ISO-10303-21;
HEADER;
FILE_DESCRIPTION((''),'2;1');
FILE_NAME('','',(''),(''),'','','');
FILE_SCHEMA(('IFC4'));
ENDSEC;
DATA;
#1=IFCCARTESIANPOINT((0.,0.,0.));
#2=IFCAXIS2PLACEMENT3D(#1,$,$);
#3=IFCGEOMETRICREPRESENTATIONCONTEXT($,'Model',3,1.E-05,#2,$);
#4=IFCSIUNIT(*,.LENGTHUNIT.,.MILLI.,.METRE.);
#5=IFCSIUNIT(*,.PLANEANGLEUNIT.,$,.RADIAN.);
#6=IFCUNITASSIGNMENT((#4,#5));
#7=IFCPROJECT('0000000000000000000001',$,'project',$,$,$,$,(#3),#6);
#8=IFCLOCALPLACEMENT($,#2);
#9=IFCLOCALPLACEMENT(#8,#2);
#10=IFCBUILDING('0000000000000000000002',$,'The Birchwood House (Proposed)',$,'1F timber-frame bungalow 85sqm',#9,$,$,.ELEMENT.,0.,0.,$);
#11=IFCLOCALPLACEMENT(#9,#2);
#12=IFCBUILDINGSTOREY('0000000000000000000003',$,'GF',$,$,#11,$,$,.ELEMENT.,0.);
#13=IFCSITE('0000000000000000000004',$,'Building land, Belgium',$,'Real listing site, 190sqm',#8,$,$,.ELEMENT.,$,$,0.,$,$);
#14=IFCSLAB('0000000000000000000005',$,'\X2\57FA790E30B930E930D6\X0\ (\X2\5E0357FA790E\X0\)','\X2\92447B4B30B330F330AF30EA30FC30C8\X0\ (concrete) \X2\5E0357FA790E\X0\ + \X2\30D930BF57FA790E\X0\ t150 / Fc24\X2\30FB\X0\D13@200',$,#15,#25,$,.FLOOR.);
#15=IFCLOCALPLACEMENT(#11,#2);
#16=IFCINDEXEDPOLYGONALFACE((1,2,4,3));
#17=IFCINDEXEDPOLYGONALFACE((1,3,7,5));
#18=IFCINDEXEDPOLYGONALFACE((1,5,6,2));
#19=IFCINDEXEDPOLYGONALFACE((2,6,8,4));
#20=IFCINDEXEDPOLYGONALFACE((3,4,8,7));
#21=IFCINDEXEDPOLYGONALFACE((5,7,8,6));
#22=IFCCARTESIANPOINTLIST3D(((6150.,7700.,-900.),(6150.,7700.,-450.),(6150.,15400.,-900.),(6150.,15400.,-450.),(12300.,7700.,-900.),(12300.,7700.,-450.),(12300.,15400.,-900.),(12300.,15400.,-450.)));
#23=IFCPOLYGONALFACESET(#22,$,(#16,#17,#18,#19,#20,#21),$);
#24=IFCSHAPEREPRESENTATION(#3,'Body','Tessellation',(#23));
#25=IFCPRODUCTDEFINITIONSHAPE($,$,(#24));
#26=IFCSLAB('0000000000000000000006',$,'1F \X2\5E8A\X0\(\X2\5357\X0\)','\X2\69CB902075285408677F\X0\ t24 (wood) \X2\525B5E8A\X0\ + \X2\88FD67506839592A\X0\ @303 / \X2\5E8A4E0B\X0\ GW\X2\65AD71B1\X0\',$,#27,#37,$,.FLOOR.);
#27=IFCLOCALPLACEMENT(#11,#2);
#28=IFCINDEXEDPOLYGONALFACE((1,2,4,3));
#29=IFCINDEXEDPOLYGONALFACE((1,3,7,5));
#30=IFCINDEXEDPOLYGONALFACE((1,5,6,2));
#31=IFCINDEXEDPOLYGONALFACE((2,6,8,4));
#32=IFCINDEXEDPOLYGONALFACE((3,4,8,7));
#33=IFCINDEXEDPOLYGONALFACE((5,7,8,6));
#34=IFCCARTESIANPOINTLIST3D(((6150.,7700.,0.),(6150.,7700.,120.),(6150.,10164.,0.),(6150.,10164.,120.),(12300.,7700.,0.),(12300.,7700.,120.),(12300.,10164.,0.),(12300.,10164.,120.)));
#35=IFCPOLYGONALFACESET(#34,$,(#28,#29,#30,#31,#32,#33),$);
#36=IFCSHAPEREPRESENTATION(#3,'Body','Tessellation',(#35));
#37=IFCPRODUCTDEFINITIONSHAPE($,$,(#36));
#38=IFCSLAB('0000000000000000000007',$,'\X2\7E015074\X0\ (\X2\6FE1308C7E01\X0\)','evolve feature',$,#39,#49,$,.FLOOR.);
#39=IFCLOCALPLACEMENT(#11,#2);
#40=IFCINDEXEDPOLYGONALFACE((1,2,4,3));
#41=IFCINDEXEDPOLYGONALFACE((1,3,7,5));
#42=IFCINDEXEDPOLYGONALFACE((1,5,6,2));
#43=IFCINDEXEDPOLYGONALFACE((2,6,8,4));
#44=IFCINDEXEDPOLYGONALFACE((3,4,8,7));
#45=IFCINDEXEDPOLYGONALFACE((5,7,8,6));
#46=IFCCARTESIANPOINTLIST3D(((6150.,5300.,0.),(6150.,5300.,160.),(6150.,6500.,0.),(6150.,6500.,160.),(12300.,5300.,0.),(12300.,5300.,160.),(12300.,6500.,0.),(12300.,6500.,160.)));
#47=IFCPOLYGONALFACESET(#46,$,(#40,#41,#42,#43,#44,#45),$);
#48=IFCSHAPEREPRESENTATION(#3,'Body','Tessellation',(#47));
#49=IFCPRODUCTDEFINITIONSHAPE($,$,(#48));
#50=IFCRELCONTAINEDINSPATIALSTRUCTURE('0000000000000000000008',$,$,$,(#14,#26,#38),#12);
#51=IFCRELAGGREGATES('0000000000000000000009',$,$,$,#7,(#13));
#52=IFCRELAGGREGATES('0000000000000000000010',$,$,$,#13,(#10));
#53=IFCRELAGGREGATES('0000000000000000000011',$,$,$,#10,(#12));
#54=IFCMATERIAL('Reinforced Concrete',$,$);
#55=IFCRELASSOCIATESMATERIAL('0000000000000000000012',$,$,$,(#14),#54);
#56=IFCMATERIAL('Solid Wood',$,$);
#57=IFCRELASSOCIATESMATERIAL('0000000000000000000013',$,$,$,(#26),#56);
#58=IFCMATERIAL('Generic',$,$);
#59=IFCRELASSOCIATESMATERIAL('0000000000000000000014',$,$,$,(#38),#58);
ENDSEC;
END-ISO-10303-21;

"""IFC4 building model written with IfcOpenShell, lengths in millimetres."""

from ifc_helpers import new_model, si_unit, frame, frame_2d, origin, place, context, project, spatial, rectangle, extrude, material, element, save


model = new_model("IFC4")

# Units and contexts
model_context = context("Model", 3, precision=1e-05, world=origin())
ifc_project = project(units=[si_unit("LENGTHUNIT", "METRE", prefix="MILLI"), si_unit("PLANEANGLEUNIT", "RADIAN")], contexts=[model_context])

# Site, building, storey
site_placement = place(None, origin())
site = spatial("IfcSite", under=ifc_project, at=site_placement, Name="Building land, Belgium", ObjectType="Real listing site, 190sqm", CompositionType="ELEMENT", RefElevation=0.0)
building_placement = place(site_placement, origin())
building = spatial("IfcBuilding", under=site, at=building_placement, Name="The Birchwood House (Proposed)", ObjectType="1F timber-frame bungalow 85sqm", CompositionType="ELEMENT", ElevationOfRefHeight=0.0, ElevationOfTerrain=0.0)
storey_placement = place(building_placement, origin())
storey = spatial("IfcBuildingStorey", under=building, at=storey_placement, Name="GF", CompositionType="ELEMENT", Elevation=0.0)

# Slabs
ifc_material_1 = material(Name="Reinforced Concrete")
slab_1_placement = place(storey_placement, frame((3075.0, 3850.0, -450.0)))
element("IfcSlab", 1, at=slab_1_placement, inside=storey, material=ifc_material_1, Name="基礎スラブ (布基礎)", Description="鉄筋コンクリート (concrete) 布基礎 + ベタ基礎 t150 / Fc24・D13@200", PredefinedType="FLOOR", context=model_context, shape_type="SweptSolid", body=[
    extrude(rectangle(XDim=6150.0, YDim=7700.0, at=frame_2d((3075.0, 3850.0))), frame((3075.0, 3850.0, -450.0)), (0.0, 0.0, 1.0), 450.0),
])
ifc_material_2 = material(Name="Solid Wood")
slab_2_placement = place(storey_placement, frame((3075.0, 3850.0, 0.0)))
element("IfcSlab", 2, at=slab_2_placement, inside=storey, material=ifc_material_2, Name="1F 床(南)", Description="構造用合板 t24 (wood) 剛床 + 製材根太 @303 / 床下 GW断熱", PredefinedType="FLOOR", context=model_context, shape_type="SweptSolid", body=[
    extrude(rectangle(XDim=6150.0, YDim=2464.0, at=frame_2d((3075.0, 1232.0))), frame((3075.0, 3850.0, 0.0)), (0.0, 0.0, 1.0), 120.0),
])
ifc_material_3 = material(Name="Generic")
slab_3_placement = place(storey_placement, frame((3075.0, 2650.0, 0.0)))
element("IfcSlab", 3, at=slab_3_placement, inside=storey, material=ifc_material_3, Name="縁側 (濡れ縁)", Description="evolve feature", PredefinedType="FLOOR", context=model_context, shape_type="SweptSolid", body=[
    extrude(rectangle(XDim=6150.0, YDim=1200.0, at=frame_2d((3075.0, 600.0))), frame((3075.0, 2650.0, 0.0)), (0.0, 0.0, 1.0), 160.0),
])

save(model, "model.ifc")
